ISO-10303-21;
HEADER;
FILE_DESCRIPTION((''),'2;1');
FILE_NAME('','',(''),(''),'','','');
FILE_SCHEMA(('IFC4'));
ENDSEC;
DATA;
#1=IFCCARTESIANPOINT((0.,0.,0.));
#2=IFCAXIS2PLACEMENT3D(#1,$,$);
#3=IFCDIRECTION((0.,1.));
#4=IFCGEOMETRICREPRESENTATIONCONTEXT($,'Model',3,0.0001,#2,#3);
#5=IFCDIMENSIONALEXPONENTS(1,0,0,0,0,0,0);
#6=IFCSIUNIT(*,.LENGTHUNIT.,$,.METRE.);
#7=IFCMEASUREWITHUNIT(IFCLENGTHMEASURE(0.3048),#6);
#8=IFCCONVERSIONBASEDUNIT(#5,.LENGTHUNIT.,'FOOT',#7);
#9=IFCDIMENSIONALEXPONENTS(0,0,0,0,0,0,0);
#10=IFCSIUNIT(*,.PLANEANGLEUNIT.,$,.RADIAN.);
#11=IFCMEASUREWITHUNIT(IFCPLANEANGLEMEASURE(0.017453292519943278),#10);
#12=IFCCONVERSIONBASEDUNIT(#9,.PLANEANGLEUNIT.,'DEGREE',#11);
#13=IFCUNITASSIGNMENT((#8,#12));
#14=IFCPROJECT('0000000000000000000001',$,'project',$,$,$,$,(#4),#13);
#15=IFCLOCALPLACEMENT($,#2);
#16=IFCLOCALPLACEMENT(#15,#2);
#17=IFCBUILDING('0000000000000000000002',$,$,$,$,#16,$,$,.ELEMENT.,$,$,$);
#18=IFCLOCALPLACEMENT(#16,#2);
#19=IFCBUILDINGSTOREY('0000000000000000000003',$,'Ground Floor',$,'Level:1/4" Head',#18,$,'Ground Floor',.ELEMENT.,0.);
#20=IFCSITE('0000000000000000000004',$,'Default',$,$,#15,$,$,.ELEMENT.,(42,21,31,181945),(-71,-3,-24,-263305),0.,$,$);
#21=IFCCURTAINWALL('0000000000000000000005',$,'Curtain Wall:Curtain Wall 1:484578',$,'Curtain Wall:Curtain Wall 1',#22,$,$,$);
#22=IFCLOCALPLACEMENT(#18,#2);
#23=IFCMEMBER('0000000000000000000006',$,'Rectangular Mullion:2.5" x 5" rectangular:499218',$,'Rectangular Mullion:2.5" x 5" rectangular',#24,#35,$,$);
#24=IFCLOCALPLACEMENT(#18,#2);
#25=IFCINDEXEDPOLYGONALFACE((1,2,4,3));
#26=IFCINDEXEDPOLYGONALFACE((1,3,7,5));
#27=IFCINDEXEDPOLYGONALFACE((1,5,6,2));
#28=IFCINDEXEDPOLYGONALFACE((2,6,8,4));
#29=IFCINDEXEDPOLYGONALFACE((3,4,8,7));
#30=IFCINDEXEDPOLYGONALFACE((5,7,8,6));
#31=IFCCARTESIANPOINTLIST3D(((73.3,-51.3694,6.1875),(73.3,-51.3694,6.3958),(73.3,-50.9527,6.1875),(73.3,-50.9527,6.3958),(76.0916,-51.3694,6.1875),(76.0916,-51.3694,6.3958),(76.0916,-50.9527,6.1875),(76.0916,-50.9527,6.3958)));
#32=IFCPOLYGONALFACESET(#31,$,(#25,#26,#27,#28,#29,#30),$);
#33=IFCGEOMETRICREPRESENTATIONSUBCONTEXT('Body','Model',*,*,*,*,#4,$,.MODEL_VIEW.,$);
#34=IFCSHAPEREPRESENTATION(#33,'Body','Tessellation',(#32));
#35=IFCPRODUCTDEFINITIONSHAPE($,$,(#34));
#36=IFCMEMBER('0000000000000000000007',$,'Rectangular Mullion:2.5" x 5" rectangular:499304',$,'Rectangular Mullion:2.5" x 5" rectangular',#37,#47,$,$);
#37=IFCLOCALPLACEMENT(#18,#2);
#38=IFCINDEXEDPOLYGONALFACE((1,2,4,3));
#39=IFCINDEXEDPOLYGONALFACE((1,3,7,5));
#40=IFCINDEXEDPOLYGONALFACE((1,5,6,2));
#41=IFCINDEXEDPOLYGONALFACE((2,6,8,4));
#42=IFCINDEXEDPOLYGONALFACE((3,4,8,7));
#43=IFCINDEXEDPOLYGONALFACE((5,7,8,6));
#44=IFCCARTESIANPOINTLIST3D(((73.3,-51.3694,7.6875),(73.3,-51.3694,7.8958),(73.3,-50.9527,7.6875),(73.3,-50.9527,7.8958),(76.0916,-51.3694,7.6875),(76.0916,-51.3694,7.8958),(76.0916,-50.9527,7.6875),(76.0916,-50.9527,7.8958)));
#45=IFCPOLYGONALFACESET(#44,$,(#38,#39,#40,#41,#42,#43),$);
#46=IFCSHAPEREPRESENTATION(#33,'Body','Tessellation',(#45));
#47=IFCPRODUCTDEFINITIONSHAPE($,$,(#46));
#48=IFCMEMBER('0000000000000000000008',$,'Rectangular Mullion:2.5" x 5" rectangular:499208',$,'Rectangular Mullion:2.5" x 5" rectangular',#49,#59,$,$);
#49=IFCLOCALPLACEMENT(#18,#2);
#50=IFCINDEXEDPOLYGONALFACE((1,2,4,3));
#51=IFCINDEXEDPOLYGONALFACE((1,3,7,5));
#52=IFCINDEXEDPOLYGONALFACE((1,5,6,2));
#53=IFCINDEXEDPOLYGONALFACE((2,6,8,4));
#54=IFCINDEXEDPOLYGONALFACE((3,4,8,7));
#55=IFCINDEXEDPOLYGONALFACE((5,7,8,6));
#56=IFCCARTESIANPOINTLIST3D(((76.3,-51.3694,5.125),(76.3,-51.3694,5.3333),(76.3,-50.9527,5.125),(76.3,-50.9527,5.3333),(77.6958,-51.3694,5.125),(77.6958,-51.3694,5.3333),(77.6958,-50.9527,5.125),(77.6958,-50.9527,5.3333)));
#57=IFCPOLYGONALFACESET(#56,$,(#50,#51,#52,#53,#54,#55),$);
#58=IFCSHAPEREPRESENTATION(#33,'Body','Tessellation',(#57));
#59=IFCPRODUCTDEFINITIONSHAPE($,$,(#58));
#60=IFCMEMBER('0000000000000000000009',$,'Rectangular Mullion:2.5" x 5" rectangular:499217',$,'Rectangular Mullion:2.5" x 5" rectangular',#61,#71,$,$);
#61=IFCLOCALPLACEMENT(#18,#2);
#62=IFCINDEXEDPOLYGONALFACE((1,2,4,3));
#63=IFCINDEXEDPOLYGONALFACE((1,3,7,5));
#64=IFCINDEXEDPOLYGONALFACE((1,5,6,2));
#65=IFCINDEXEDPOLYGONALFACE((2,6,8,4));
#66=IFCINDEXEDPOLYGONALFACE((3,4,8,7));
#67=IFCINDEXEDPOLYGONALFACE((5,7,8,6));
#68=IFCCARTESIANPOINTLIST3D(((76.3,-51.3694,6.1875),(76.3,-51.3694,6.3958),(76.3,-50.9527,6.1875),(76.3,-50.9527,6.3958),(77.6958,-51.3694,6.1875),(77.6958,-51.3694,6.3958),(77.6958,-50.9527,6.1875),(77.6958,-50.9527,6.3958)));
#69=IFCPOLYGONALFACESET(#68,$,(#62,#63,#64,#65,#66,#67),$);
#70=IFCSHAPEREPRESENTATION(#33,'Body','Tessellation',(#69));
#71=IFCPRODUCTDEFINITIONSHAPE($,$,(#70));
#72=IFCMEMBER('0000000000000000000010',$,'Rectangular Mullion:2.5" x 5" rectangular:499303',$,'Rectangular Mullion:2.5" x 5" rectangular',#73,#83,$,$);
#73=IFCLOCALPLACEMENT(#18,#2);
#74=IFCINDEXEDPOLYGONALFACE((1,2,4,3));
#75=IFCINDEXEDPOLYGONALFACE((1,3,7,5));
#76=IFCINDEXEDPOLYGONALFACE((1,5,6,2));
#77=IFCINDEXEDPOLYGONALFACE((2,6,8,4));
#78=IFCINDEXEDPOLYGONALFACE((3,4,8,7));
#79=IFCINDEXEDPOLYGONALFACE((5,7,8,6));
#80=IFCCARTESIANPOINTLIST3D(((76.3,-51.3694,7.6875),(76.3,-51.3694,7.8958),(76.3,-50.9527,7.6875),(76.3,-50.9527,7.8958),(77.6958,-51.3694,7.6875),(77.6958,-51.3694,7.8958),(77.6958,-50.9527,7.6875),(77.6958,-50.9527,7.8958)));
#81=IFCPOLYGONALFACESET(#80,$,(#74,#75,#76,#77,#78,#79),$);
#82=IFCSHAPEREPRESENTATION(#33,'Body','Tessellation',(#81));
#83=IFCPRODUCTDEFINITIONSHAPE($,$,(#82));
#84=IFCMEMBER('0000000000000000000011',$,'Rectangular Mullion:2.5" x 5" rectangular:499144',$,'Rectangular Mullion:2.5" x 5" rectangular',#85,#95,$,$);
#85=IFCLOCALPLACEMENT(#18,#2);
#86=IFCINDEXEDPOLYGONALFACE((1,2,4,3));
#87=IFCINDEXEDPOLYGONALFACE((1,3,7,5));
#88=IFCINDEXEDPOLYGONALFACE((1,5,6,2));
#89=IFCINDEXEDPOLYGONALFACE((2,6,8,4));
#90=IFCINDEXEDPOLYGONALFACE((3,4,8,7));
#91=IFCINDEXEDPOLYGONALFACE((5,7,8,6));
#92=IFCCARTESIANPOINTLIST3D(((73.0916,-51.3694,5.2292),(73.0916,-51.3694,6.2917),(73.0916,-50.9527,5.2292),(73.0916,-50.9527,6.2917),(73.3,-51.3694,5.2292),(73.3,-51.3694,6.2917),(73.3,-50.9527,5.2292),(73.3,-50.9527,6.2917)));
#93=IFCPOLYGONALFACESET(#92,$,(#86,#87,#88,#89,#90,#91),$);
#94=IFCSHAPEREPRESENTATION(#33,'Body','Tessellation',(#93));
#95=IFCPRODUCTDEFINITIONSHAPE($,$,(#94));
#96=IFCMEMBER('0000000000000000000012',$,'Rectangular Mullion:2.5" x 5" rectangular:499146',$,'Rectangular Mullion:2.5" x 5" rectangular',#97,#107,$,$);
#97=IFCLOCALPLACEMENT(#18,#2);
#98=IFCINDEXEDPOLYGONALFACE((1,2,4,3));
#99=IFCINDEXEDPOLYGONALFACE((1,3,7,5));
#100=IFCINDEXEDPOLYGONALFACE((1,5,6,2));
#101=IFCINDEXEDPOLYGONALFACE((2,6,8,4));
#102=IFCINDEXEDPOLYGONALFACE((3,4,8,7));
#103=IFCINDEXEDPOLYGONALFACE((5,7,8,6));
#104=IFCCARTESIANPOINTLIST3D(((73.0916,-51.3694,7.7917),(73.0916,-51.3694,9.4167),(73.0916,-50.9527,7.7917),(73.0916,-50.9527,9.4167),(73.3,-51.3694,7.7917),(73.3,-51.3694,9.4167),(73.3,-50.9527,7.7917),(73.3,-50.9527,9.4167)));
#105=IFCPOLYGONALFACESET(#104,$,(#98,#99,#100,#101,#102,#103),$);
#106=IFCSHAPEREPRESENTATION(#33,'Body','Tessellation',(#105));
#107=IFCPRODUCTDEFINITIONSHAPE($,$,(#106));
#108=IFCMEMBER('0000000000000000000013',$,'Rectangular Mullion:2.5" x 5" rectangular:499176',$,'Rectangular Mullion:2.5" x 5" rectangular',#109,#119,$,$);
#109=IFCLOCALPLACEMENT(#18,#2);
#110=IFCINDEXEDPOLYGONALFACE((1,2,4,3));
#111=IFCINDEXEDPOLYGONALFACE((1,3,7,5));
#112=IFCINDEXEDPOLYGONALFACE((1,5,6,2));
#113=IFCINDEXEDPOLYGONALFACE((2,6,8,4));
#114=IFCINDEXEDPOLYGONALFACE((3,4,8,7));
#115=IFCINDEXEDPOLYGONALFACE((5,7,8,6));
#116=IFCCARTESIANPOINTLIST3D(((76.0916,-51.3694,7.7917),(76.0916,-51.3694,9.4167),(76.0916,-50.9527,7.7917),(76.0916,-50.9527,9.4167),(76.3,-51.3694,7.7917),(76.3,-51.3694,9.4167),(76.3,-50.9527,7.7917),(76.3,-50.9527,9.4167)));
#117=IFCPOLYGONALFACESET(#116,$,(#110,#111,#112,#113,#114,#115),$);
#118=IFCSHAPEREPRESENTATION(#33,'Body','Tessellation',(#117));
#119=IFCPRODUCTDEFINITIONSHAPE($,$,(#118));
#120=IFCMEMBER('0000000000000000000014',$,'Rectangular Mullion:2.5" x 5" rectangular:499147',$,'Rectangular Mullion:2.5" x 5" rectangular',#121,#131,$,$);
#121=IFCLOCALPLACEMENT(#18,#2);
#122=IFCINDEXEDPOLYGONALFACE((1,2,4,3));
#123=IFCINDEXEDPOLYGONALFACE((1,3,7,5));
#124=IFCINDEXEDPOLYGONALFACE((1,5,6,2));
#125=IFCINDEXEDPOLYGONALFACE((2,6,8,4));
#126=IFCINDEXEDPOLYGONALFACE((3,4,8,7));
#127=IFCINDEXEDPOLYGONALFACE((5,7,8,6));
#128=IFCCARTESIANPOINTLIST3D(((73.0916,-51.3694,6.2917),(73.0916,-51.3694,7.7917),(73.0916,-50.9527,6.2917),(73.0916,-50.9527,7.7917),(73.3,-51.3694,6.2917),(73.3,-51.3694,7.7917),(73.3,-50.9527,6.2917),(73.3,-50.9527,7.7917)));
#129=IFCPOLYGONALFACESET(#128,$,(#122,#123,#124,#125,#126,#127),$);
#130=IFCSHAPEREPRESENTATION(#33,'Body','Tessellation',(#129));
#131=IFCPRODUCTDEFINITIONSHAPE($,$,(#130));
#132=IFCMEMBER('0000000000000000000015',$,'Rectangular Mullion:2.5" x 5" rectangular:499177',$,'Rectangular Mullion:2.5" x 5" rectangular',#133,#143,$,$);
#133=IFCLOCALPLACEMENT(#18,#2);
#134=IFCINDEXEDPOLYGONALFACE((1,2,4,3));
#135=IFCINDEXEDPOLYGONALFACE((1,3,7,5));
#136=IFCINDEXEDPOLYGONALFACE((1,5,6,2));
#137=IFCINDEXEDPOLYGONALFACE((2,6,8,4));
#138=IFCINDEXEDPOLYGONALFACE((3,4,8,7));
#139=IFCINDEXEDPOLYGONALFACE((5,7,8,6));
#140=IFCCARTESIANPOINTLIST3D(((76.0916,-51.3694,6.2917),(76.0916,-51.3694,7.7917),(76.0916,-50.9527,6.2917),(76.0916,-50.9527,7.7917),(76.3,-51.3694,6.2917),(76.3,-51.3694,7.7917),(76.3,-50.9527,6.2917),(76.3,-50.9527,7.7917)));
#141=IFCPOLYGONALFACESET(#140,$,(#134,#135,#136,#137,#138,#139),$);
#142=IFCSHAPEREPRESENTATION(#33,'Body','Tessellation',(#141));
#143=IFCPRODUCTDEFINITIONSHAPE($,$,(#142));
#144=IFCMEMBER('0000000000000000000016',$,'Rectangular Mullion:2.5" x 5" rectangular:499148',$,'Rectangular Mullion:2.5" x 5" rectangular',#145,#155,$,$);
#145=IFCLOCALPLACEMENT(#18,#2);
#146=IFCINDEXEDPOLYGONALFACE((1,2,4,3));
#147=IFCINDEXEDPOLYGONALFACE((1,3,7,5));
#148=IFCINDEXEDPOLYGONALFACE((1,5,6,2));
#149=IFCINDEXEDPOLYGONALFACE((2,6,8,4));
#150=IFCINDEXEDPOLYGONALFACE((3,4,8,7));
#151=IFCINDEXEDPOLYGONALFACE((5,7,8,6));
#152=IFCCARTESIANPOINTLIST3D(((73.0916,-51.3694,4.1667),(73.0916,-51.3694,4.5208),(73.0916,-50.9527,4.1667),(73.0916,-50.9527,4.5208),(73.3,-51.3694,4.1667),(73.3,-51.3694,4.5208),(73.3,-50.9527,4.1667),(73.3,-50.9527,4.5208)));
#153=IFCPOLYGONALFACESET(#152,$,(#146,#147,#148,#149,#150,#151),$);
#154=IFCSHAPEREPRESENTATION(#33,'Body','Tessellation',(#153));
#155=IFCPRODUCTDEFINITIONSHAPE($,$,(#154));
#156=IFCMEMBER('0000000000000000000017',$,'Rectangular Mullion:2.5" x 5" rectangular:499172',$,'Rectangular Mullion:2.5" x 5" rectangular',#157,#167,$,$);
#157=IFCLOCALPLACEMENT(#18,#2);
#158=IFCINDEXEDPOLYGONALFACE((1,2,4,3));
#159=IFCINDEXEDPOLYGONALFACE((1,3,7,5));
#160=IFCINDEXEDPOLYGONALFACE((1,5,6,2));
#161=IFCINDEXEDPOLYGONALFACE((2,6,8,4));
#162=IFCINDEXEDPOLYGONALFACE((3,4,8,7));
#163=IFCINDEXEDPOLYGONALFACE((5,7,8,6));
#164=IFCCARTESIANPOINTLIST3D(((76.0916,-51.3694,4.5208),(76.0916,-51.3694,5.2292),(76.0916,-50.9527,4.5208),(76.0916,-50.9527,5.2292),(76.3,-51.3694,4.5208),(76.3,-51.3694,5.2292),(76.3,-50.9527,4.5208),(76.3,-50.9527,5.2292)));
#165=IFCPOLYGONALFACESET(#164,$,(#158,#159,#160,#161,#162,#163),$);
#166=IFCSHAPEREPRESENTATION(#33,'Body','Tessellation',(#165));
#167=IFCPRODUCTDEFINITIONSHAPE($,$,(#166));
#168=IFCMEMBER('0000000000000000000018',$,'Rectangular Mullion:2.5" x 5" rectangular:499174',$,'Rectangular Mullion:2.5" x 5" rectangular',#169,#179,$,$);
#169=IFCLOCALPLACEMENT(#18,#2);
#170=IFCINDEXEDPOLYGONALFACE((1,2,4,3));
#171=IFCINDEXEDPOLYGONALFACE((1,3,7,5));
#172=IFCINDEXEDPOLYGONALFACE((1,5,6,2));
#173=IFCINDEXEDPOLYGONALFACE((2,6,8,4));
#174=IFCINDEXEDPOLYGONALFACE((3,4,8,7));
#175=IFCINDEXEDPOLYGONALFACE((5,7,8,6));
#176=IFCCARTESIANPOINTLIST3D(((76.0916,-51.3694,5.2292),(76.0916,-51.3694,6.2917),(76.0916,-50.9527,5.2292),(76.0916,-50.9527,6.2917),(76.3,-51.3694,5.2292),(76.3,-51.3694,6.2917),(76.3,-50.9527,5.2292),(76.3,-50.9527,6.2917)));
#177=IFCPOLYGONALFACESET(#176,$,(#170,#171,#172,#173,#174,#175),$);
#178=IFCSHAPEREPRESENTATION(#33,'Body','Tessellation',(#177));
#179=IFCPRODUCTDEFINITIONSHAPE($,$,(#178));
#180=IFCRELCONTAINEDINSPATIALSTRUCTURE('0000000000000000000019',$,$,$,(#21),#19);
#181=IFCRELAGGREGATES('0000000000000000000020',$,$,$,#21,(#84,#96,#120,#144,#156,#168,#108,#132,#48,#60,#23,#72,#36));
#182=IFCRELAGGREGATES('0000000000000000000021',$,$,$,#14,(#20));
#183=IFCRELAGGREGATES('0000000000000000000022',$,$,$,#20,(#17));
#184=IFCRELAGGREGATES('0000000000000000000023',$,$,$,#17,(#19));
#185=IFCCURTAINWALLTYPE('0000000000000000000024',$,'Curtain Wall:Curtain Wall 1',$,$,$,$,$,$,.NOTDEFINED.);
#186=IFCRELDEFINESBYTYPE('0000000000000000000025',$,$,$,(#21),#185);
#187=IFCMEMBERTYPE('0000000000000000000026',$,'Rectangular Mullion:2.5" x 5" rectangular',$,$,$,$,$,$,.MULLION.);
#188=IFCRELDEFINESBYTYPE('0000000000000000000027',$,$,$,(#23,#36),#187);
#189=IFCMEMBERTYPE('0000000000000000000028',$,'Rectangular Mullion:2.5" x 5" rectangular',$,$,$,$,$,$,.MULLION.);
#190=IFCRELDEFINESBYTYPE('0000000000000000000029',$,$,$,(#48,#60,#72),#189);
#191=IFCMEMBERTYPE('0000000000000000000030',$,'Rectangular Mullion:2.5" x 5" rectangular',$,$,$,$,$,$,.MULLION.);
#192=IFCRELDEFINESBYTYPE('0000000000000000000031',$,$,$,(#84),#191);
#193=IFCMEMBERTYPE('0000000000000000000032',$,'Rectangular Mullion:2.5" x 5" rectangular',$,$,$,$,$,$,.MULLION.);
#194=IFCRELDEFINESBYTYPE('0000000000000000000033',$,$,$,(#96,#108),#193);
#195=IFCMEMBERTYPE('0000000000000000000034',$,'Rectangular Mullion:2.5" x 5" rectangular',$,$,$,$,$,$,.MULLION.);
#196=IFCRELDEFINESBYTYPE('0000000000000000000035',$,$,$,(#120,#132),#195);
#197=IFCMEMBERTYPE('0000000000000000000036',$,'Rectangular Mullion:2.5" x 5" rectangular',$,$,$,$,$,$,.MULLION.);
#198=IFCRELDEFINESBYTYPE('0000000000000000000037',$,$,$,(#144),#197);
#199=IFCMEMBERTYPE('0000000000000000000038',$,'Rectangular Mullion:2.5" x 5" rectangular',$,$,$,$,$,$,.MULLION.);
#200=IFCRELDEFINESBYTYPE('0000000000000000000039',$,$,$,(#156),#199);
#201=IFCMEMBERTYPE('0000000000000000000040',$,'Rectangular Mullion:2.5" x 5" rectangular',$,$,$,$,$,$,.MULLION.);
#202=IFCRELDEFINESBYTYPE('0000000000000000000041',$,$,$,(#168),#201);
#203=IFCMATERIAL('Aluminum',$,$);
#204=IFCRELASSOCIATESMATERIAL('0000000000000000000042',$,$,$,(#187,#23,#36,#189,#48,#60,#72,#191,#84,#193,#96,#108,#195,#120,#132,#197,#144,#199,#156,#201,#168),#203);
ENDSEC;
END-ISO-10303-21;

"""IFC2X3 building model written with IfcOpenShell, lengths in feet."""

from ifc_helpers import new_model, entity, si_unit, converted_unit, direction, frame, origin, origin_2d_with_axis, place, context, subcontext, project, spatial, rectangle, extrude, source, transform, mapped, material, type_object, type_shapes, element, aggregate, save


model = new_model("IFC2X3")

# Units and contexts
model_context = context("Model", 3, precision=0.0001, world=origin(), true_north=direction((0.0, 1.0)))
body_context = subcontext(model_context, "Body", "Model", "MODEL_VIEW")
ifc_project = project(units=[converted_unit("LENGTHUNIT", "FOOT", entity("IfcLengthMeasure", 0.3048), si_unit("LENGTHUNIT", "METRE"), dimensions=[1, 0, 0, 0, 0, 0, 0]), converted_unit("PLANEANGLEUNIT", "DEGREE", entity("IfcPlaneAngleMeasure", 0.017453292519943278), si_unit("PLANEANGLEUNIT", "RADIAN"), dimensions=[0, 0, 0, 0, 0, 0, 0])], contexts=[model_context])

# Site, building, storey
site_placement = place(None, origin())
site = spatial("IfcSite", under=ifc_project, at=site_placement, Name="Default", CompositionType="ELEMENT", RefLatitude=(42, 21, 31, 181945), RefLongitude=(-71, -3, -24, -263305), RefElevation=0.0)
building_placement = place(site_placement, origin())
building = spatial("IfcBuilding", under=site, at=building_placement, CompositionType="ELEMENT")
storey_placement = place(building_placement, origin())
storey = spatial("IfcBuildingStorey", under=building, at=storey_placement, Name="Ground Floor", ObjectType="Level:1/4\" Head", LongName="Ground Floor", CompositionType="ELEMENT", Elevation=0.0)

# Curtain wall, members
curtain_wall_type = type_object("IfcCurtainWallType", Name="Curtain Wall:Curtain Wall 1", PredefinedType="NOTDEFINED")
curtain_wall_placement = place(storey_placement, origin())
curtain_wall = element("IfcCurtainWall", 1, at=curtain_wall_placement, inside=storey, type_object=curtain_wall_type, Name="Curtain Wall:Curtain Wall 1:484578", ObjectType="Curtain Wall:Curtain Wall 1")
ifc_material_1 = material(Name="Aluminum")
member_type_1 = type_object("IfcMemberType", Name="Rectangular Mullion:2.5\" x 5\" rectangular", PredefinedType="MULLION", material=ifc_material_1)
shared_shape_1 = source(origin(), body_context, "Body", "SweptSolid", [
    extrude(rectangle(XDim=0.2083, YDim=0.4167, at=origin_2d_with_axis()), frame((0.0, 0.0, -2.7917), z_axis=(0.0, 0.0, 1.0), x_axis=(-1.0, 0.0, 0.0)), (0.0, 0.0, 1.0), 2.7917),
])
type_shapes(member_type_1, [shared_shape_1])
member_1_placement = place(curtain_wall_placement, frame((76.0916, -51.161, 6.2917), z_axis=(1.0, 0.0, 0.0), x_axis=(0.0, 0.0, 1.0)))
member_1 = element("IfcMember", 2, at=member_1_placement, type_object=member_type_1, material=ifc_material_1, Name="Rectangular Mullion:2.5\" x 5\" rectangular:499218", ObjectType="Rectangular Mullion:2.5\" x 5\" rectangular", context=body_context, shape_type="MappedRepresentation", body=[
    mapped(shared_shape_1, transform((0.0, 0.0, 0.0), scale=1.0)),
])
member_2_placement = place(curtain_wall_placement, frame((76.0916, -51.161, 7.7917), z_axis=(1.0, 0.0, 0.0), x_axis=(0.0, 0.0, 1.0)))
member_2 = element("IfcMember", 3, at=member_2_placement, type_object=member_type_1, material=ifc_material_1, Name="Rectangular Mullion:2.5\" x 5\" rectangular:499304", ObjectType="Rectangular Mullion:2.5\" x 5\" rectangular", context=body_context, shape_type="MappedRepresentation", body=[
    mapped(shared_shape_1, transform((0.0, 0.0, 0.0), scale=1.0)),
])
member_type_2 = type_object("IfcMemberType", Name="Rectangular Mullion:2.5\" x 5\" rectangular", PredefinedType="MULLION", material=ifc_material_1)
shared_shape_2 = source(origin(), body_context, "Body", "SweptSolid", [
    extrude(rectangle(XDim=0.2083, YDim=0.4167, at=origin_2d_with_axis()), frame((0.0, 0.0, -1.3958), z_axis=(0.0, 0.0, 1.0), x_axis=(-1.0, 0.0, 0.0)), (0.0, 0.0, 1.0), 1.3958),
])
type_shapes(member_type_2, [shared_shape_2])
member_3_placement = place(curtain_wall_placement, frame((77.6958, -51.161, 5.2292), z_axis=(1.0, 0.0, 0.0), x_axis=(0.0, 0.0, 1.0)))
member_3 = element("IfcMember", 4, at=member_3_placement, type_object=member_type_2, material=ifc_material_1, Name="Rectangular Mullion:2.5\" x 5\" rectangular:499208", ObjectType="Rectangular Mullion:2.5\" x 5\" rectangular", context=body_context, shape_type="MappedRepresentation", body=[
    mapped(shared_shape_2, transform((0.0, 0.0, 0.0), scale=1.0)),
])
member_4_placement = place(curtain_wall_placement, frame((77.6958, -51.161, 6.2917), z_axis=(1.0, 0.0, 0.0), x_axis=(0.0, 0.0, 1.0)))
member_4 = element("IfcMember", 5, at=member_4_placement, type_object=member_type_2, material=ifc_material_1, Name="Rectangular Mullion:2.5\" x 5\" rectangular:499217", ObjectType="Rectangular Mullion:2.5\" x 5\" rectangular", context=body_context, shape_type="MappedRepresentation", body=[
    mapped(shared_shape_2, transform((0.0, 0.0, 0.0), scale=1.0)),
])
member_5_placement = place(curtain_wall_placement, frame((77.6958, -51.161, 7.7917), z_axis=(1.0, 0.0, 0.0), x_axis=(0.0, 0.0, 1.0)))
member_5 = element("IfcMember", 6, at=member_5_placement, type_object=member_type_2, material=ifc_material_1, Name="Rectangular Mullion:2.5\" x 5\" rectangular:499303", ObjectType="Rectangular Mullion:2.5\" x 5\" rectangular", context=body_context, shape_type="MappedRepresentation", body=[
    mapped(shared_shape_2, transform((0.0, 0.0, 0.0), scale=1.0)),
])
member_type_3 = type_object("IfcMemberType", Name="Rectangular Mullion:2.5\" x 5\" rectangular", PredefinedType="MULLION", material=ifc_material_1)
shared_shape_3 = source(origin(), body_context, "Body", "SweptSolid", [
    extrude(rectangle(XDim=0.2083, YDim=0.4167, at=origin_2d_with_axis()), frame((0.0, 0.0, -1.0625), z_axis=(0.0, 0.0, 1.0), x_axis=(-1.0, 0.0, 0.0)), (0.0, 0.0, 1.0), 1.0625),
])
type_shapes(member_type_3, [shared_shape_3])
member_6_placement = place(curtain_wall_placement, frame((73.1958, -51.161, 5.2292), z_axis=(0.0, 0.0, -1.0), x_axis=(1.0, 0.0, 0.0)))
member_6 = element("IfcMember", 7, at=member_6_placement, type_object=member_type_3, material=ifc_material_1, Name="Rectangular Mullion:2.5\" x 5\" rectangular:499144", ObjectType="Rectangular Mullion:2.5\" x 5\" rectangular", context=body_context, shape_type="MappedRepresentation", body=[
    mapped(shared_shape_3, transform((0.0, 0.0, 0.0), scale=1.0)),
])
member_type_4 = type_object("IfcMemberType", Name="Rectangular Mullion:2.5\" x 5\" rectangular", PredefinedType="MULLION", material=ifc_material_1)
shared_shape_4 = source(origin(), body_context, "Body", "SweptSolid", [
    extrude(rectangle(XDim=0.2083, YDim=0.4167, at=origin_2d_with_axis()), frame((0.0, 0.0, -1.625), z_axis=(0.0, 0.0, 1.0), x_axis=(-1.0, 0.0, 0.0)), (0.0, 0.0, 1.0), 1.625),
])
type_shapes(member_type_4, [shared_shape_4])
member_7_placement = place(curtain_wall_placement, frame((73.1958, -51.161, 7.7917), z_axis=(0.0, 0.0, -1.0), x_axis=(1.0, 0.0, 0.0)))
member_7 = element("IfcMember", 8, at=member_7_placement, type_object=member_type_4, material=ifc_material_1, Name="Rectangular Mullion:2.5\" x 5\" rectangular:499146", ObjectType="Rectangular Mullion:2.5\" x 5\" rectangular", context=body_context, shape_type="MappedRepresentation", body=[
    mapped(shared_shape_4, transform((0.0, 0.0, 0.0), scale=1.0)),
])
member_8_placement = place(curtain_wall_placement, frame((76.1958, -51.161, 7.7917), z_axis=(0.0, 0.0, -1.0), x_axis=(1.0, 0.0, 0.0)))
member_8 = element("IfcMember", 9, at=member_8_placement, type_object=member_type_4, material=ifc_material_1, Name="Rectangular Mullion:2.5\" x 5\" rectangular:499176", ObjectType="Rectangular Mullion:2.5\" x 5\" rectangular", context=body_context, shape_type="MappedRepresentation", body=[
    mapped(shared_shape_4, transform((0.0, 0.0, 0.0), scale=1.0)),
])
member_type_5 = type_object("IfcMemberType", Name="Rectangular Mullion:2.5\" x 5\" rectangular", PredefinedType="MULLION", material=ifc_material_1)
shared_shape_5 = source(origin(), body_context, "Body", "SweptSolid", [
    extrude(rectangle(XDim=0.2083, YDim=0.4167, at=origin_2d_with_axis()), frame((0.0, 0.0, -1.5), z_axis=(0.0, 0.0, 1.0), x_axis=(-1.0, 0.0, 0.0)), (0.0, 0.0, 1.0), 1.5),
])
type_shapes(member_type_5, [shared_shape_5])
member_9_placement = place(curtain_wall_placement, frame((73.1958, -51.161, 6.2917), z_axis=(0.0, 0.0, -1.0), x_axis=(1.0, 0.0, 0.0)))
member_9 = element("IfcMember", 10, at=member_9_placement, type_object=member_type_5, material=ifc_material_1, Name="Rectangular Mullion:2.5\" x 5\" rectangular:499147", ObjectType="Rectangular Mullion:2.5\" x 5\" rectangular", context=body_context, shape_type="MappedRepresentation", body=[
    mapped(shared_shape_5, transform((0.0, 0.0, 0.0), scale=1.0)),
])
member_10_placement = place(curtain_wall_placement, frame((76.1958, -51.161, 6.2917), z_axis=(0.0, 0.0, -1.0), x_axis=(1.0, 0.0, 0.0)))
member_10 = element("IfcMember", 11, at=member_10_placement, type_object=member_type_5, material=ifc_material_1, Name="Rectangular Mullion:2.5\" x 5\" rectangular:499177", ObjectType="Rectangular Mullion:2.5\" x 5\" rectangular", context=body_context, shape_type="MappedRepresentation", body=[
    mapped(shared_shape_5, transform((0.0, 0.0, 0.0), scale=1.0)),
])
member_type_6 = type_object("IfcMemberType", Name="Rectangular Mullion:2.5\" x 5\" rectangular", PredefinedType="MULLION", material=ifc_material_1)
shared_shape_6 = source(origin(), body_context, "Body", "SweptSolid", [
    extrude(rectangle(XDim=0.2083, YDim=0.4167, at=origin_2d_with_axis()), frame((0.0, 0.0, -0.3542), z_axis=(0.0, 0.0, 1.0), x_axis=(-1.0, 0.0, 0.0)), (0.0, 0.0, 1.0), 0.3542),
])
type_shapes(member_type_6, [shared_shape_6])
member_11_placement = place(curtain_wall_placement, frame((73.1958, -51.161, 4.1667), z_axis=(0.0, 0.0, -1.0), x_axis=(1.0, 0.0, 0.0)))
member_11 = element("IfcMember", 12, at=member_11_placement, type_object=member_type_6, material=ifc_material_1, Name="Rectangular Mullion:2.5\" x 5\" rectangular:499148", ObjectType="Rectangular Mullion:2.5\" x 5\" rectangular", context=body_context, shape_type="MappedRepresentation", body=[
    mapped(shared_shape_6, transform((0.0, 0.0, 0.0), scale=1.0)),
])
member_type_7 = type_object("IfcMemberType", Name="Rectangular Mullion:2.5\" x 5\" rectangular", PredefinedType="MULLION", material=ifc_material_1)
shared_shape_7 = source(origin(), body_context, "Body", "SweptSolid", [
    extrude(rectangle(XDim=0.2083, YDim=0.4167, at=origin_2d_with_axis()), frame((0.0, 0.0, -0.7083), z_axis=(0.0, 0.0, 1.0), x_axis=(-1.0, 0.0, 0.0)), (0.0, 0.0, 1.0), 0.7083),
])
type_shapes(member_type_7, [shared_shape_7])
member_12_placement = place(curtain_wall_placement, frame((76.1958, -51.161, 4.5208), z_axis=(0.0, 0.0, -1.0), x_axis=(1.0, 0.0, 0.0)))
member_12 = element("IfcMember", 13, at=member_12_placement, type_object=member_type_7, material=ifc_material_1, Name="Rectangular Mullion:2.5\" x 5\" rectangular:499172", ObjectType="Rectangular Mullion:2.5\" x 5\" rectangular", context=body_context, shape_type="MappedRepresentation", body=[
    mapped(shared_shape_7, transform((0.0, 0.0, 0.0), scale=1.0)),
])
member_type_8 = type_object("IfcMemberType", Name="Rectangular Mullion:2.5\" x 5\" rectangular", PredefinedType="MULLION", material=ifc_material_1)
shared_shape_8 = source(origin(), body_context, "Body", "SweptSolid", [
    extrude(rectangle(XDim=0.2083, YDim=0.4167, at=origin_2d_with_axis()), frame((0.0, 0.0, -1.0625), z_axis=(0.0, 0.0, 1.0), x_axis=(-1.0, 0.0, 0.0)), (0.0, 0.0, 1.0), 1.0625),
])
type_shapes(member_type_8, [shared_shape_8])
member_13_placement = place(curtain_wall_placement, frame((76.1958, -51.161, 5.2292), z_axis=(0.0, 0.0, -1.0), x_axis=(1.0, 0.0, 0.0)))
member_13 = element("IfcMember", 14, at=member_13_placement, type_object=member_type_8, material=ifc_material_1, Name="Rectangular Mullion:2.5\" x 5\" rectangular:499174", ObjectType="Rectangular Mullion:2.5\" x 5\" rectangular", context=body_context, shape_type="MappedRepresentation", body=[
    mapped(shared_shape_8, transform((0.0, 0.0, 0.0), scale=1.0)),
])
aggregate(curtain_wall, [member_6, member_7, member_9, member_11, member_12, member_13, member_8, member_10, member_3, member_4, member_1, member_5, member_2])

save(model, "model.ifc")
